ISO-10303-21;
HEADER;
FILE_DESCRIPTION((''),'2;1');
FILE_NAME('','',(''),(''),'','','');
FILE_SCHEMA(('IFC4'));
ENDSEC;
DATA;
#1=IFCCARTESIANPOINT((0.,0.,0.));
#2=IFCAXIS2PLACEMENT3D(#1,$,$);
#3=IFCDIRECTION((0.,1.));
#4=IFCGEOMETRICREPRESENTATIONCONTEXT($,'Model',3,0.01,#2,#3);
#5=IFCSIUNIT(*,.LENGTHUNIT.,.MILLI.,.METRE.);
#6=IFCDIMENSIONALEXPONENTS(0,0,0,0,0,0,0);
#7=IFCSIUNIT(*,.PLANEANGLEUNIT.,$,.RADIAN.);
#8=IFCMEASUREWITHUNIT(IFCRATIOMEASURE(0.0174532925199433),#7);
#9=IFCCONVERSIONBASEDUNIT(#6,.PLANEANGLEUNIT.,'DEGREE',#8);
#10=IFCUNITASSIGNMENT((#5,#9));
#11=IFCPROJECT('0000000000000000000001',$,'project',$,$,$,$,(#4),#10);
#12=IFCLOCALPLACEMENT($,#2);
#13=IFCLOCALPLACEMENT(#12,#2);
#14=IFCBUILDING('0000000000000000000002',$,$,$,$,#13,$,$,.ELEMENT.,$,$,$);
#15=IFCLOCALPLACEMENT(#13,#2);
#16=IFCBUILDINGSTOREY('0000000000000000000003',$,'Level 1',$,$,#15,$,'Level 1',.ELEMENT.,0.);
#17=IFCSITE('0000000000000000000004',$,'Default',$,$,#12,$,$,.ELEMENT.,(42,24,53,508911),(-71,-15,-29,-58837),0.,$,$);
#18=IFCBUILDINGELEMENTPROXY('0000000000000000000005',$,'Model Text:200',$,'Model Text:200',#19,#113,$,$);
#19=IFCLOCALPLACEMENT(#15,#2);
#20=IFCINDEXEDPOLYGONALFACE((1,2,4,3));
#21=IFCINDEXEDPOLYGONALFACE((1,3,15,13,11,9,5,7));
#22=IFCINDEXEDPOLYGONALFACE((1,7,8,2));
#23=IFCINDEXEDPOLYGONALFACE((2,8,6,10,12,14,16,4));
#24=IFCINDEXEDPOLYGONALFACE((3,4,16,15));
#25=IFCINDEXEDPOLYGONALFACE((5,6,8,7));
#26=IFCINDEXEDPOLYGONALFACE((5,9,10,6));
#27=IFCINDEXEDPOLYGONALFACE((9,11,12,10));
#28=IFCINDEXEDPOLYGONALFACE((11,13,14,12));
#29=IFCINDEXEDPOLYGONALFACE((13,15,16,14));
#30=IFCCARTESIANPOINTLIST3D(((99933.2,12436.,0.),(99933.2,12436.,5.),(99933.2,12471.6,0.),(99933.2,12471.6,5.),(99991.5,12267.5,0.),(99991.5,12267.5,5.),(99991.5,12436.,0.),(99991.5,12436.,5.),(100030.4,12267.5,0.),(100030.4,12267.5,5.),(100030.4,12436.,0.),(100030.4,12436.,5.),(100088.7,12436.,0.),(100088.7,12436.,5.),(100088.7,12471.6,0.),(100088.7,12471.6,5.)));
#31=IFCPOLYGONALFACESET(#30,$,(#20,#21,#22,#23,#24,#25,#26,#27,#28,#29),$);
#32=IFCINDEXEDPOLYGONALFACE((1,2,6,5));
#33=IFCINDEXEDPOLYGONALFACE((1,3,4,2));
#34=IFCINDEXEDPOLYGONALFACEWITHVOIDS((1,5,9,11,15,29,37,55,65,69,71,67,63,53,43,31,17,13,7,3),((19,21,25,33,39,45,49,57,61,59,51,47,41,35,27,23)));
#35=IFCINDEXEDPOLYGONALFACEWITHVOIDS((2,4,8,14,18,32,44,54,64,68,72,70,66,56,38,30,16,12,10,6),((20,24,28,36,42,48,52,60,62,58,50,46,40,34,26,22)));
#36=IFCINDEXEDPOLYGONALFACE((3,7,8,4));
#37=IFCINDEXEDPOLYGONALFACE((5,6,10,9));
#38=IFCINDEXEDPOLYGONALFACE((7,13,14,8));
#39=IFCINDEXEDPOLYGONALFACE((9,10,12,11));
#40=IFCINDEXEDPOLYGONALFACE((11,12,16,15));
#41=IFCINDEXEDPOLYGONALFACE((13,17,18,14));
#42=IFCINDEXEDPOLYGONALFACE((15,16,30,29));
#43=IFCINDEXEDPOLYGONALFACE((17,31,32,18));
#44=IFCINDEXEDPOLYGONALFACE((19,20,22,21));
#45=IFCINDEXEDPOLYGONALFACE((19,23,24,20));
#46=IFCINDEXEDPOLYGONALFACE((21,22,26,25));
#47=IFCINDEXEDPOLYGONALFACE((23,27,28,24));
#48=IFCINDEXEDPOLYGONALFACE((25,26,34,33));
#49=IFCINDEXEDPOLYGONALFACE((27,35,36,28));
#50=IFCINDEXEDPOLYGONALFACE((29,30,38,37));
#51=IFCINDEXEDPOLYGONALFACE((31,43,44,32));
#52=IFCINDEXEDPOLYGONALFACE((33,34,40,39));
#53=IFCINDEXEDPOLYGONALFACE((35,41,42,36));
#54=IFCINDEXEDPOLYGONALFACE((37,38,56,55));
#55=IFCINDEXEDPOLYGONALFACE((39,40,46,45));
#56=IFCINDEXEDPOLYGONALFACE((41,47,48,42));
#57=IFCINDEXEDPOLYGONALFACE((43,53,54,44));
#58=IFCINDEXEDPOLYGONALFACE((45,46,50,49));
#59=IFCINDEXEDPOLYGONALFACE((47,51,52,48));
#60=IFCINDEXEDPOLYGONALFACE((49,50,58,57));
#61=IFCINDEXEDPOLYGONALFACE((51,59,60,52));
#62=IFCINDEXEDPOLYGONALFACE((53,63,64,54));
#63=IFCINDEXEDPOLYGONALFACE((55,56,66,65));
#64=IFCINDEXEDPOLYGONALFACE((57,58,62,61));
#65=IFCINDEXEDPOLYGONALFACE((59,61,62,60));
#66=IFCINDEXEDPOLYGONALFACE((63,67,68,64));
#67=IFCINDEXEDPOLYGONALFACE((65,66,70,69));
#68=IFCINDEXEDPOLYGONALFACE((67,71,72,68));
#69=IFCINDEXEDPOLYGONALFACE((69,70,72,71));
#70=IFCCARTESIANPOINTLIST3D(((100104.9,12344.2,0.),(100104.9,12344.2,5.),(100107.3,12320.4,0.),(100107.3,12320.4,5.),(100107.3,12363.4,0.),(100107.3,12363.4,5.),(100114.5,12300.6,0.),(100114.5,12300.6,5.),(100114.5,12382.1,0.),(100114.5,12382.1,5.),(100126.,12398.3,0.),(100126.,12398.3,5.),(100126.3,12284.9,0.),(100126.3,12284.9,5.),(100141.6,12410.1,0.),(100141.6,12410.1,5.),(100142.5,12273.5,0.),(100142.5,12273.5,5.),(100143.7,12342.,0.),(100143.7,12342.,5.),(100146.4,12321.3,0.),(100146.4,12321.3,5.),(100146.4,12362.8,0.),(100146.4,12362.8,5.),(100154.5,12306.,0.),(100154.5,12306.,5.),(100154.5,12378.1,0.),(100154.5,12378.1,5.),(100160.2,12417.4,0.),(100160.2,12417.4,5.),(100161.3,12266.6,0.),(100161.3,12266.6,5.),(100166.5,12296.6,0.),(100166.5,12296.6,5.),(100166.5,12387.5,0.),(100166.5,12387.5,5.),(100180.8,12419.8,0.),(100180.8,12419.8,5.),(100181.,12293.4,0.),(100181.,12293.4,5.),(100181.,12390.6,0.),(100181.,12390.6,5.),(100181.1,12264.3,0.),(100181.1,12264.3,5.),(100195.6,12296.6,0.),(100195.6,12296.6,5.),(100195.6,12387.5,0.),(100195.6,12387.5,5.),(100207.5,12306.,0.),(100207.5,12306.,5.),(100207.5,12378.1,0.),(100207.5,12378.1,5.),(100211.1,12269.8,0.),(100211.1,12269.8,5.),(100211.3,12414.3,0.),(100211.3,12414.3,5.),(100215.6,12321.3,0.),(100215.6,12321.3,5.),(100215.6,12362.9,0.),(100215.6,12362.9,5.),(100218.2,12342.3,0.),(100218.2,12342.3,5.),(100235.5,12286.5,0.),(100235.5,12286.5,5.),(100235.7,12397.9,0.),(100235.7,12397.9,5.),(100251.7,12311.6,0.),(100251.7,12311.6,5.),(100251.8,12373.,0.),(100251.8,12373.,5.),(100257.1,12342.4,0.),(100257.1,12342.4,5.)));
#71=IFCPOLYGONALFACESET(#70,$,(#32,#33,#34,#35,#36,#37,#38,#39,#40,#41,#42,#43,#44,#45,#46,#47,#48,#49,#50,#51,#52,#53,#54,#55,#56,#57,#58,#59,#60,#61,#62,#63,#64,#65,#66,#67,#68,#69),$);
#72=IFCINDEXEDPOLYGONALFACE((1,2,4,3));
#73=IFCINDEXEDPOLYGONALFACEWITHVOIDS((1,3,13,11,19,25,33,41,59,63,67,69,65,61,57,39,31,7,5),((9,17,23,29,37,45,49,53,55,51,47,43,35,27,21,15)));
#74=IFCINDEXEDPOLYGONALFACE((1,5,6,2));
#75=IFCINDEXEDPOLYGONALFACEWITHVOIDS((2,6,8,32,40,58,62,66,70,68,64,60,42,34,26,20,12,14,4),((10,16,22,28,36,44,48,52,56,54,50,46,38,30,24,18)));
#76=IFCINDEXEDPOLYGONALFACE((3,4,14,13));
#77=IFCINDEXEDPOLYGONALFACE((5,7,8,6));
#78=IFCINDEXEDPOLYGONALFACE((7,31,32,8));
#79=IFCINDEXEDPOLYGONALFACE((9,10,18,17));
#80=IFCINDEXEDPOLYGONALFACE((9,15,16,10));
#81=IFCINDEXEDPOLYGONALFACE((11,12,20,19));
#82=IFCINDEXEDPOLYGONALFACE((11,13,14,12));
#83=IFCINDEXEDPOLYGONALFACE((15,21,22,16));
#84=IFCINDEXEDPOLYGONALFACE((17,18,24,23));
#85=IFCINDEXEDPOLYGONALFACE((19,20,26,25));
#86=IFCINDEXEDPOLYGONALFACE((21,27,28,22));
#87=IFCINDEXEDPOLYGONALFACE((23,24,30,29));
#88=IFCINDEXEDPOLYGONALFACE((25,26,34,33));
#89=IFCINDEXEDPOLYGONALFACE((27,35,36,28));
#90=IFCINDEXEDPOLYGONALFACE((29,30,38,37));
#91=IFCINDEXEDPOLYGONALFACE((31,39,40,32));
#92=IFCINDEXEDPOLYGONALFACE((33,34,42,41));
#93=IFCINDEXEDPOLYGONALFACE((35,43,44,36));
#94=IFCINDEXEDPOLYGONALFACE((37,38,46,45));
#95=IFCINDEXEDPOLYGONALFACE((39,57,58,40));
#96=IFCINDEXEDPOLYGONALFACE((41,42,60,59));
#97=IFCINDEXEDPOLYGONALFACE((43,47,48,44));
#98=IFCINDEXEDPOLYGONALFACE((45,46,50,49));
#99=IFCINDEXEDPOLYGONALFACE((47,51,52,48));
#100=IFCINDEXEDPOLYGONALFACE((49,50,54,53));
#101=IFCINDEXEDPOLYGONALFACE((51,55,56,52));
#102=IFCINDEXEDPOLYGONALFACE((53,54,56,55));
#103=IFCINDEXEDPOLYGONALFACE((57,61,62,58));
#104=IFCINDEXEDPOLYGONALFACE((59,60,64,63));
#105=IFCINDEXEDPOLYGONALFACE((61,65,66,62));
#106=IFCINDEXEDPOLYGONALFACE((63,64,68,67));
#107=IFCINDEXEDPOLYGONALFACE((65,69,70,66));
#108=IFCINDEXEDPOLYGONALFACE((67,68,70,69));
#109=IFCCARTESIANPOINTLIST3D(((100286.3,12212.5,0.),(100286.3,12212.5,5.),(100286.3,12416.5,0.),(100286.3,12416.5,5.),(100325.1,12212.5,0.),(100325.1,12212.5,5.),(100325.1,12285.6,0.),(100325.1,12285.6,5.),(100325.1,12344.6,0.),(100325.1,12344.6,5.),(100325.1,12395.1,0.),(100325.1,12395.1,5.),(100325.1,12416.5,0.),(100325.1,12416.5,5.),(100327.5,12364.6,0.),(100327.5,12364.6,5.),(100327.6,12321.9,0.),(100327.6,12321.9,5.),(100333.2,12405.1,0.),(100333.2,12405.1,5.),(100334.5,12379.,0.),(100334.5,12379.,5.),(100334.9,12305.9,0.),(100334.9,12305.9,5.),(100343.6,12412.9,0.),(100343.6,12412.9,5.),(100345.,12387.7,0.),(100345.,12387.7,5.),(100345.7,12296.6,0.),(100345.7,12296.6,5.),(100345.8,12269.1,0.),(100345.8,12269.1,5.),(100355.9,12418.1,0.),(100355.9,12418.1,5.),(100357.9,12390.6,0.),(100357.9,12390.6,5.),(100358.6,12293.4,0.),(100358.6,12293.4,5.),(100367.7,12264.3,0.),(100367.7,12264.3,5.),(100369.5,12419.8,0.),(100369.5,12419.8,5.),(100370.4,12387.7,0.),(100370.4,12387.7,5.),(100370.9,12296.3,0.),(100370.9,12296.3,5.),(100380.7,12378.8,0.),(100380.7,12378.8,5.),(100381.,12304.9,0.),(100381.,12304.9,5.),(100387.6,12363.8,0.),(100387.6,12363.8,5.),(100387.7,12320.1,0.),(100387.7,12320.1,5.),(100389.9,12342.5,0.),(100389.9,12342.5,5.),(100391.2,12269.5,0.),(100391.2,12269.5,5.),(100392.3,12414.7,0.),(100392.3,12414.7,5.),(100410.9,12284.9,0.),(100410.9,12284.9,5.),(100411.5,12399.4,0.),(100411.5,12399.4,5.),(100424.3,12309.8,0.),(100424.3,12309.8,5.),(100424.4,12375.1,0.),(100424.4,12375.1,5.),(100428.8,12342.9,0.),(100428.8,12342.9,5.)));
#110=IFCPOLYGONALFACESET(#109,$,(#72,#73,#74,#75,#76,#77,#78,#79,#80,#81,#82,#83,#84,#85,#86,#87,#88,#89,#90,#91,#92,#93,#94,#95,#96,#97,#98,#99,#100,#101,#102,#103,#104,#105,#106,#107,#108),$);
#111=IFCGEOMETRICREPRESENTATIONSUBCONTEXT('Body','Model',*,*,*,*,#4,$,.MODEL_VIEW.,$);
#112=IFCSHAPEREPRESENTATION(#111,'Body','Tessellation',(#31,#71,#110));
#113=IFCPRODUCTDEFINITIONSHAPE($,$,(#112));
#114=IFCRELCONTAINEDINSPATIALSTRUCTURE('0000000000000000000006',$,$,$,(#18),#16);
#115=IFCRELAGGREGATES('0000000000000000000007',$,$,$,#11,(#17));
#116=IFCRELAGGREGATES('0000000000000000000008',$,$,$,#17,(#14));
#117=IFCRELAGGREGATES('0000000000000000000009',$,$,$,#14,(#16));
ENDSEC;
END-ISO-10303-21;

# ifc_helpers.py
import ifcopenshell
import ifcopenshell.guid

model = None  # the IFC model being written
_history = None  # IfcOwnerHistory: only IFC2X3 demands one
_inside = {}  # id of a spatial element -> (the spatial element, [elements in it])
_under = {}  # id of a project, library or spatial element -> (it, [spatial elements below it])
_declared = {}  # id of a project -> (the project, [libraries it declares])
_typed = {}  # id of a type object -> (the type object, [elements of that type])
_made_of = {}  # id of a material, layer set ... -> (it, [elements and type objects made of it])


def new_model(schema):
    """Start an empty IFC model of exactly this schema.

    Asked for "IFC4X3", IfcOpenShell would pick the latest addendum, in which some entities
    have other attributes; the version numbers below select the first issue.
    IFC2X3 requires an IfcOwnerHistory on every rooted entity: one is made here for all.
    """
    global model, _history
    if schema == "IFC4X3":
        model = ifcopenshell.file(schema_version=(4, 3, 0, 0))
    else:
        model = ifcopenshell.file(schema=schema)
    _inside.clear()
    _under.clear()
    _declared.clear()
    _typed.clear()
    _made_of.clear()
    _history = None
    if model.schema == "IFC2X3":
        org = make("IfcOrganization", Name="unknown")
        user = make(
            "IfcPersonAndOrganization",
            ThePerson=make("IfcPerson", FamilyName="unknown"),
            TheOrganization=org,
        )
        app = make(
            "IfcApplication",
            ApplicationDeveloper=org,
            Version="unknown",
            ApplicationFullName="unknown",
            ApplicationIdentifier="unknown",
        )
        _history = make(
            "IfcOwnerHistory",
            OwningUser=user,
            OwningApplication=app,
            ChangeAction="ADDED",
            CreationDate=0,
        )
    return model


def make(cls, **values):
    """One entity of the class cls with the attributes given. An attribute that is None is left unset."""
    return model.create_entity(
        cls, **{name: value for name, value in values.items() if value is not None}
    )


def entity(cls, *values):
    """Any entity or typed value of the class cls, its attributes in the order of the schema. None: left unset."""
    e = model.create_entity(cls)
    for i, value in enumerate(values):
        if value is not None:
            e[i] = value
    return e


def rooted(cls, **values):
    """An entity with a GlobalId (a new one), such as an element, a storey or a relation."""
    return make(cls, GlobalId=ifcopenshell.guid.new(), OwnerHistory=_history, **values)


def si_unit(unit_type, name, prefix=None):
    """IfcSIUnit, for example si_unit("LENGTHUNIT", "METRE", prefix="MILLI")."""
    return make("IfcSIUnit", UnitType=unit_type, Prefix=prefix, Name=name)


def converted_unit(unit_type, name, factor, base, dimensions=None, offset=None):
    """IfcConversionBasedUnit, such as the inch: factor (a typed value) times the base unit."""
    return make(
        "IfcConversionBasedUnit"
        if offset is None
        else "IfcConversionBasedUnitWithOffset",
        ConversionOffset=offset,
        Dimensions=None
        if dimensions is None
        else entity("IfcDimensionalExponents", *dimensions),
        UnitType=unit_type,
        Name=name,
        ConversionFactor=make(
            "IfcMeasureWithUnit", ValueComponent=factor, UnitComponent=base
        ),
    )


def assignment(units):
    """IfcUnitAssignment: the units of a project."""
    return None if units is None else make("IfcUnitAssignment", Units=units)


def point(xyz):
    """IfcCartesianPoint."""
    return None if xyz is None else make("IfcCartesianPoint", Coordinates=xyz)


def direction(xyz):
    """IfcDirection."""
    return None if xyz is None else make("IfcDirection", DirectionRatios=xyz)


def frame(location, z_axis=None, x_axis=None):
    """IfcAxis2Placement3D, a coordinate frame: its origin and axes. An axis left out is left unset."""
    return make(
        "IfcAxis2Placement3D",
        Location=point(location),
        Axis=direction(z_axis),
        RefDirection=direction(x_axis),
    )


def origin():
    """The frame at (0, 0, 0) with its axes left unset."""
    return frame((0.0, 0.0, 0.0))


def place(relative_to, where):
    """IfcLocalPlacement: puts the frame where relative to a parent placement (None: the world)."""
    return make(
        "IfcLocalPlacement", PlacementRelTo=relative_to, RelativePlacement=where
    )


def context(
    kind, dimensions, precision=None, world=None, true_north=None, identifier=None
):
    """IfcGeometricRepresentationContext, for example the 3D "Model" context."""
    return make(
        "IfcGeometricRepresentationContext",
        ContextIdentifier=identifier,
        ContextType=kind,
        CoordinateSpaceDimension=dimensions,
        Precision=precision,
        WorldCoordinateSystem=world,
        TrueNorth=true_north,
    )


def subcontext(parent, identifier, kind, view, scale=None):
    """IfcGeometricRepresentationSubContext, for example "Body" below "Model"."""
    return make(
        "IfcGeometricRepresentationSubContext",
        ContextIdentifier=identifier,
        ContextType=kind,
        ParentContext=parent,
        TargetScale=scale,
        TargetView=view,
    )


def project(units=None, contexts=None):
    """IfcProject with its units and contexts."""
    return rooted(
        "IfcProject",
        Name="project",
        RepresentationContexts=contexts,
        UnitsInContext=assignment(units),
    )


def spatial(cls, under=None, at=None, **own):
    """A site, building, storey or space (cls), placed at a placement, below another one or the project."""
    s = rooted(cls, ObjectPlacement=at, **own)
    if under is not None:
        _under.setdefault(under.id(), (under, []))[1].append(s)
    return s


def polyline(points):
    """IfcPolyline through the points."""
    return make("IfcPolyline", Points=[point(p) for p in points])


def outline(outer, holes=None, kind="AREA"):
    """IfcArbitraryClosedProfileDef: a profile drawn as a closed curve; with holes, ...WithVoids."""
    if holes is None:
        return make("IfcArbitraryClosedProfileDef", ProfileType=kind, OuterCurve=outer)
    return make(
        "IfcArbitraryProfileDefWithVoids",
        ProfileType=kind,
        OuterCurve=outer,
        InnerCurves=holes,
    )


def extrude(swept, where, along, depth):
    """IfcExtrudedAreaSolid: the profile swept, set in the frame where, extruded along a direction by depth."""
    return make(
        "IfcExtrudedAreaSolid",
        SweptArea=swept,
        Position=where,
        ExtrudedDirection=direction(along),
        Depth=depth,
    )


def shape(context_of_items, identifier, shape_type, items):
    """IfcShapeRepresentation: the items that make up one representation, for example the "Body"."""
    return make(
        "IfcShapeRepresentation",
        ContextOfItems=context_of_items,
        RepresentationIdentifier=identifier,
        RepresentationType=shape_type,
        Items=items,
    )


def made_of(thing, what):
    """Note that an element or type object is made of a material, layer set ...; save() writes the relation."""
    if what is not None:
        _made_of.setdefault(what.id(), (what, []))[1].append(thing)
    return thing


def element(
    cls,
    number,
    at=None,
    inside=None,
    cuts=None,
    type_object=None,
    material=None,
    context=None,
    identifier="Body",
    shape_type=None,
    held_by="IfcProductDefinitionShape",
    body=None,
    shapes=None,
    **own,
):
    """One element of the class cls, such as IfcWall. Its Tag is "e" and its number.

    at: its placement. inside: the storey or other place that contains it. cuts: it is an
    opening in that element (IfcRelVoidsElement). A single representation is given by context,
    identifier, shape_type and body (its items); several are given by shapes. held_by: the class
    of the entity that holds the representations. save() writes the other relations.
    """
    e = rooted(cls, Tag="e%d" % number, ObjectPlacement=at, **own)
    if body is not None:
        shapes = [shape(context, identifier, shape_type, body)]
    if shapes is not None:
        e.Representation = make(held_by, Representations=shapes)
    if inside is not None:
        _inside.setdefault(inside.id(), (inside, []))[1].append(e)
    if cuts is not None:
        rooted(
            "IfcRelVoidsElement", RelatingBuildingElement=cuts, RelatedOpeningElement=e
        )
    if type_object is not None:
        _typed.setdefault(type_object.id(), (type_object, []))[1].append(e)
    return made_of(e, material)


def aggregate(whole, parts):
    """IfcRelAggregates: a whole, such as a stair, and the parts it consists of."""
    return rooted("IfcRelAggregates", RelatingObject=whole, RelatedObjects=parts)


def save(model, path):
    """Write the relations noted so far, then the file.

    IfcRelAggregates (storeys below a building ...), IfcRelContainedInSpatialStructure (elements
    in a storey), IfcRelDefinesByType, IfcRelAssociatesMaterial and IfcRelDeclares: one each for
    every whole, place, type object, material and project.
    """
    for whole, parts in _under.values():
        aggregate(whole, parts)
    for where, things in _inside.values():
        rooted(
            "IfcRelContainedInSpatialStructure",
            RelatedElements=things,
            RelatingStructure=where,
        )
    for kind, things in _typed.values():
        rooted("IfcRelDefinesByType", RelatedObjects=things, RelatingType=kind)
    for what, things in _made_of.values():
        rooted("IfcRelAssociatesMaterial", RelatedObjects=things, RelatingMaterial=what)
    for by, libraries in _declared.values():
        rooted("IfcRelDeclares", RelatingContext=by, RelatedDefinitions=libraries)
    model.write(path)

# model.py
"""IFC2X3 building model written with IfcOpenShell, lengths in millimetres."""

from ifc_helpers import new_model, entity, si_unit, converted_unit, direction, frame, origin, place, context, subcontext, project, spatial, polyline, outline, extrude, element, save


model = new_model("IFC2X3")

# Units and contexts
model_context = context("Model", 3, precision=0.01, world=origin(), true_north=direction((0.0, 1.0)))
body_context = subcontext(model_context, "Body", "Model", "MODEL_VIEW")
ifc_project = project(units=[si_unit("LENGTHUNIT", "METRE", prefix="MILLI"), converted_unit("PLANEANGLEUNIT", "DEGREE", entity("IfcRatioMeasure", 0.0174532925199433), si_unit("PLANEANGLEUNIT", "RADIAN"), dimensions=[0, 0, 0, 0, 0, 0, 0])], contexts=[model_context])

# Site, building, storey
site_placement = place(None, origin())
site = spatial("IfcSite", under=ifc_project, at=site_placement, Name="Default", CompositionType="ELEMENT", RefLatitude=(42, 24, 53, 508911), RefLongitude=(-71, -15, -29, -58837), RefElevation=0.0)
building_placement = place(site_placement, origin())
building = spatial("IfcBuilding", under=site, at=building_placement, CompositionType="ELEMENT")
storey_placement = place(building_placement, origin())
storey = spatial("IfcBuildingStorey", under=building, at=storey_placement, Name="Level 1", LongName="Level 1", CompositionType="ELEMENT", Elevation=0.0)

# Building element proxy
proxy_1_placement = place(storey_placement, origin())
element("IfcBuildingElementProxy", 1, at=proxy_1_placement, inside=storey, Name="Model Text:200", ObjectType="Model Text:200", context=body_context, shape_type="SweptSolid", body=[
    extrude(outline(polyline([(-19.4, -135.2), (19.4, -135.2), (19.4, 33.2), (77.7, 33.2), (77.7, 68.8), (-77.7, 68.8), (-77.7, 33.2), (-19.4, 33.2), (-19.4, -135.2)])), frame((100010.9, 12402.8, 0.0)), (0.0, 0.0, 1.0), 5.0),
    extrude(outline(polyline([(-8.8, -65.7), (15.1, -65.7), (35.5, -60.5), (52.3, -50.4), (65.3, -35.4), (74.1, -17.3), (78.4, 2.1), (75.9, 32.5), (61.8, 58.5), (38.4, 77.1), (8.3, 85.6), (-22.7, 83.3), (-49.0, 69.9), (-67.8, 47.3), (-76.3, 17.5), (-76.0, -3.3), (-70.7, -22.5), (-60.5, -39.2), (-45.5, -52.3), (-27.7, -61.4), (-8.8, -65.7)]), holes=[polyline([(-2.7, -27.2), (-23.1, -22.5), (-37.5, -12.9), (-45.7, 0.0), (-47.3, 14.8), (-42.7, 28.9), (-32.2, 39.9), (-16.3, 46.3), (4.5, 46.9), (25.1, 42.1), (39.6, 32.6), (47.7, 19.7), (49.4, 5.0), (44.8, -9.2), (34.2, -20.2), (18.2, -26.7), (-2.7, -27.2)])]), frame((100171.1, 12342.1, 0.0), z_axis=(0.0, 0.0, 1.0), x_axis=(0.100608, -0.994926, 0.0)), (0.0, 0.0, 1.0), 5.0),
    extrude(outline(polyline([(-73.1, -75.4), (130.9, -75.4), (130.9, -36.6), (57.8, -36.6), (74.3, -15.9), (79.1, 6.0), (73.9, 29.5), (58.4, 49.2), (33.6, 62.6), (0.5, 67.1), (-31.8, 62.8), (-56.1, 49.8), (-71.3, 30.7), (-76.4, 7.8), (-74.7, -5.8), (-69.6, -18.1), (-61.7, -28.5), (-51.7, -36.6), (-73.1, -36.6), (-73.1, -75.4)]), holes=[polyline([(-1.2, -36.6), (-21.2, -34.2), (-35.6, -27.2), (-44.3, -16.7), (-47.2, -3.8), (-44.3, 8.7), (-35.4, 19.0), (-20.4, 25.9), (0.8, 28.2), (23.3, 26.0), (38.5, 19.3), (47.1, 9.2), (49.9, -3.1), (46.8, -16.0), (37.4, -26.8), (21.5, -34.1), (-1.2, -36.6)])]), frame((100361.7, 12343.4, 0.0), z_axis=(0.0, 0.0, 1.0), x_axis=(0.0, -1.0, 0.0)), (0.0, 0.0, 1.0), 5.0),
])

save(model, "model.ifc")
